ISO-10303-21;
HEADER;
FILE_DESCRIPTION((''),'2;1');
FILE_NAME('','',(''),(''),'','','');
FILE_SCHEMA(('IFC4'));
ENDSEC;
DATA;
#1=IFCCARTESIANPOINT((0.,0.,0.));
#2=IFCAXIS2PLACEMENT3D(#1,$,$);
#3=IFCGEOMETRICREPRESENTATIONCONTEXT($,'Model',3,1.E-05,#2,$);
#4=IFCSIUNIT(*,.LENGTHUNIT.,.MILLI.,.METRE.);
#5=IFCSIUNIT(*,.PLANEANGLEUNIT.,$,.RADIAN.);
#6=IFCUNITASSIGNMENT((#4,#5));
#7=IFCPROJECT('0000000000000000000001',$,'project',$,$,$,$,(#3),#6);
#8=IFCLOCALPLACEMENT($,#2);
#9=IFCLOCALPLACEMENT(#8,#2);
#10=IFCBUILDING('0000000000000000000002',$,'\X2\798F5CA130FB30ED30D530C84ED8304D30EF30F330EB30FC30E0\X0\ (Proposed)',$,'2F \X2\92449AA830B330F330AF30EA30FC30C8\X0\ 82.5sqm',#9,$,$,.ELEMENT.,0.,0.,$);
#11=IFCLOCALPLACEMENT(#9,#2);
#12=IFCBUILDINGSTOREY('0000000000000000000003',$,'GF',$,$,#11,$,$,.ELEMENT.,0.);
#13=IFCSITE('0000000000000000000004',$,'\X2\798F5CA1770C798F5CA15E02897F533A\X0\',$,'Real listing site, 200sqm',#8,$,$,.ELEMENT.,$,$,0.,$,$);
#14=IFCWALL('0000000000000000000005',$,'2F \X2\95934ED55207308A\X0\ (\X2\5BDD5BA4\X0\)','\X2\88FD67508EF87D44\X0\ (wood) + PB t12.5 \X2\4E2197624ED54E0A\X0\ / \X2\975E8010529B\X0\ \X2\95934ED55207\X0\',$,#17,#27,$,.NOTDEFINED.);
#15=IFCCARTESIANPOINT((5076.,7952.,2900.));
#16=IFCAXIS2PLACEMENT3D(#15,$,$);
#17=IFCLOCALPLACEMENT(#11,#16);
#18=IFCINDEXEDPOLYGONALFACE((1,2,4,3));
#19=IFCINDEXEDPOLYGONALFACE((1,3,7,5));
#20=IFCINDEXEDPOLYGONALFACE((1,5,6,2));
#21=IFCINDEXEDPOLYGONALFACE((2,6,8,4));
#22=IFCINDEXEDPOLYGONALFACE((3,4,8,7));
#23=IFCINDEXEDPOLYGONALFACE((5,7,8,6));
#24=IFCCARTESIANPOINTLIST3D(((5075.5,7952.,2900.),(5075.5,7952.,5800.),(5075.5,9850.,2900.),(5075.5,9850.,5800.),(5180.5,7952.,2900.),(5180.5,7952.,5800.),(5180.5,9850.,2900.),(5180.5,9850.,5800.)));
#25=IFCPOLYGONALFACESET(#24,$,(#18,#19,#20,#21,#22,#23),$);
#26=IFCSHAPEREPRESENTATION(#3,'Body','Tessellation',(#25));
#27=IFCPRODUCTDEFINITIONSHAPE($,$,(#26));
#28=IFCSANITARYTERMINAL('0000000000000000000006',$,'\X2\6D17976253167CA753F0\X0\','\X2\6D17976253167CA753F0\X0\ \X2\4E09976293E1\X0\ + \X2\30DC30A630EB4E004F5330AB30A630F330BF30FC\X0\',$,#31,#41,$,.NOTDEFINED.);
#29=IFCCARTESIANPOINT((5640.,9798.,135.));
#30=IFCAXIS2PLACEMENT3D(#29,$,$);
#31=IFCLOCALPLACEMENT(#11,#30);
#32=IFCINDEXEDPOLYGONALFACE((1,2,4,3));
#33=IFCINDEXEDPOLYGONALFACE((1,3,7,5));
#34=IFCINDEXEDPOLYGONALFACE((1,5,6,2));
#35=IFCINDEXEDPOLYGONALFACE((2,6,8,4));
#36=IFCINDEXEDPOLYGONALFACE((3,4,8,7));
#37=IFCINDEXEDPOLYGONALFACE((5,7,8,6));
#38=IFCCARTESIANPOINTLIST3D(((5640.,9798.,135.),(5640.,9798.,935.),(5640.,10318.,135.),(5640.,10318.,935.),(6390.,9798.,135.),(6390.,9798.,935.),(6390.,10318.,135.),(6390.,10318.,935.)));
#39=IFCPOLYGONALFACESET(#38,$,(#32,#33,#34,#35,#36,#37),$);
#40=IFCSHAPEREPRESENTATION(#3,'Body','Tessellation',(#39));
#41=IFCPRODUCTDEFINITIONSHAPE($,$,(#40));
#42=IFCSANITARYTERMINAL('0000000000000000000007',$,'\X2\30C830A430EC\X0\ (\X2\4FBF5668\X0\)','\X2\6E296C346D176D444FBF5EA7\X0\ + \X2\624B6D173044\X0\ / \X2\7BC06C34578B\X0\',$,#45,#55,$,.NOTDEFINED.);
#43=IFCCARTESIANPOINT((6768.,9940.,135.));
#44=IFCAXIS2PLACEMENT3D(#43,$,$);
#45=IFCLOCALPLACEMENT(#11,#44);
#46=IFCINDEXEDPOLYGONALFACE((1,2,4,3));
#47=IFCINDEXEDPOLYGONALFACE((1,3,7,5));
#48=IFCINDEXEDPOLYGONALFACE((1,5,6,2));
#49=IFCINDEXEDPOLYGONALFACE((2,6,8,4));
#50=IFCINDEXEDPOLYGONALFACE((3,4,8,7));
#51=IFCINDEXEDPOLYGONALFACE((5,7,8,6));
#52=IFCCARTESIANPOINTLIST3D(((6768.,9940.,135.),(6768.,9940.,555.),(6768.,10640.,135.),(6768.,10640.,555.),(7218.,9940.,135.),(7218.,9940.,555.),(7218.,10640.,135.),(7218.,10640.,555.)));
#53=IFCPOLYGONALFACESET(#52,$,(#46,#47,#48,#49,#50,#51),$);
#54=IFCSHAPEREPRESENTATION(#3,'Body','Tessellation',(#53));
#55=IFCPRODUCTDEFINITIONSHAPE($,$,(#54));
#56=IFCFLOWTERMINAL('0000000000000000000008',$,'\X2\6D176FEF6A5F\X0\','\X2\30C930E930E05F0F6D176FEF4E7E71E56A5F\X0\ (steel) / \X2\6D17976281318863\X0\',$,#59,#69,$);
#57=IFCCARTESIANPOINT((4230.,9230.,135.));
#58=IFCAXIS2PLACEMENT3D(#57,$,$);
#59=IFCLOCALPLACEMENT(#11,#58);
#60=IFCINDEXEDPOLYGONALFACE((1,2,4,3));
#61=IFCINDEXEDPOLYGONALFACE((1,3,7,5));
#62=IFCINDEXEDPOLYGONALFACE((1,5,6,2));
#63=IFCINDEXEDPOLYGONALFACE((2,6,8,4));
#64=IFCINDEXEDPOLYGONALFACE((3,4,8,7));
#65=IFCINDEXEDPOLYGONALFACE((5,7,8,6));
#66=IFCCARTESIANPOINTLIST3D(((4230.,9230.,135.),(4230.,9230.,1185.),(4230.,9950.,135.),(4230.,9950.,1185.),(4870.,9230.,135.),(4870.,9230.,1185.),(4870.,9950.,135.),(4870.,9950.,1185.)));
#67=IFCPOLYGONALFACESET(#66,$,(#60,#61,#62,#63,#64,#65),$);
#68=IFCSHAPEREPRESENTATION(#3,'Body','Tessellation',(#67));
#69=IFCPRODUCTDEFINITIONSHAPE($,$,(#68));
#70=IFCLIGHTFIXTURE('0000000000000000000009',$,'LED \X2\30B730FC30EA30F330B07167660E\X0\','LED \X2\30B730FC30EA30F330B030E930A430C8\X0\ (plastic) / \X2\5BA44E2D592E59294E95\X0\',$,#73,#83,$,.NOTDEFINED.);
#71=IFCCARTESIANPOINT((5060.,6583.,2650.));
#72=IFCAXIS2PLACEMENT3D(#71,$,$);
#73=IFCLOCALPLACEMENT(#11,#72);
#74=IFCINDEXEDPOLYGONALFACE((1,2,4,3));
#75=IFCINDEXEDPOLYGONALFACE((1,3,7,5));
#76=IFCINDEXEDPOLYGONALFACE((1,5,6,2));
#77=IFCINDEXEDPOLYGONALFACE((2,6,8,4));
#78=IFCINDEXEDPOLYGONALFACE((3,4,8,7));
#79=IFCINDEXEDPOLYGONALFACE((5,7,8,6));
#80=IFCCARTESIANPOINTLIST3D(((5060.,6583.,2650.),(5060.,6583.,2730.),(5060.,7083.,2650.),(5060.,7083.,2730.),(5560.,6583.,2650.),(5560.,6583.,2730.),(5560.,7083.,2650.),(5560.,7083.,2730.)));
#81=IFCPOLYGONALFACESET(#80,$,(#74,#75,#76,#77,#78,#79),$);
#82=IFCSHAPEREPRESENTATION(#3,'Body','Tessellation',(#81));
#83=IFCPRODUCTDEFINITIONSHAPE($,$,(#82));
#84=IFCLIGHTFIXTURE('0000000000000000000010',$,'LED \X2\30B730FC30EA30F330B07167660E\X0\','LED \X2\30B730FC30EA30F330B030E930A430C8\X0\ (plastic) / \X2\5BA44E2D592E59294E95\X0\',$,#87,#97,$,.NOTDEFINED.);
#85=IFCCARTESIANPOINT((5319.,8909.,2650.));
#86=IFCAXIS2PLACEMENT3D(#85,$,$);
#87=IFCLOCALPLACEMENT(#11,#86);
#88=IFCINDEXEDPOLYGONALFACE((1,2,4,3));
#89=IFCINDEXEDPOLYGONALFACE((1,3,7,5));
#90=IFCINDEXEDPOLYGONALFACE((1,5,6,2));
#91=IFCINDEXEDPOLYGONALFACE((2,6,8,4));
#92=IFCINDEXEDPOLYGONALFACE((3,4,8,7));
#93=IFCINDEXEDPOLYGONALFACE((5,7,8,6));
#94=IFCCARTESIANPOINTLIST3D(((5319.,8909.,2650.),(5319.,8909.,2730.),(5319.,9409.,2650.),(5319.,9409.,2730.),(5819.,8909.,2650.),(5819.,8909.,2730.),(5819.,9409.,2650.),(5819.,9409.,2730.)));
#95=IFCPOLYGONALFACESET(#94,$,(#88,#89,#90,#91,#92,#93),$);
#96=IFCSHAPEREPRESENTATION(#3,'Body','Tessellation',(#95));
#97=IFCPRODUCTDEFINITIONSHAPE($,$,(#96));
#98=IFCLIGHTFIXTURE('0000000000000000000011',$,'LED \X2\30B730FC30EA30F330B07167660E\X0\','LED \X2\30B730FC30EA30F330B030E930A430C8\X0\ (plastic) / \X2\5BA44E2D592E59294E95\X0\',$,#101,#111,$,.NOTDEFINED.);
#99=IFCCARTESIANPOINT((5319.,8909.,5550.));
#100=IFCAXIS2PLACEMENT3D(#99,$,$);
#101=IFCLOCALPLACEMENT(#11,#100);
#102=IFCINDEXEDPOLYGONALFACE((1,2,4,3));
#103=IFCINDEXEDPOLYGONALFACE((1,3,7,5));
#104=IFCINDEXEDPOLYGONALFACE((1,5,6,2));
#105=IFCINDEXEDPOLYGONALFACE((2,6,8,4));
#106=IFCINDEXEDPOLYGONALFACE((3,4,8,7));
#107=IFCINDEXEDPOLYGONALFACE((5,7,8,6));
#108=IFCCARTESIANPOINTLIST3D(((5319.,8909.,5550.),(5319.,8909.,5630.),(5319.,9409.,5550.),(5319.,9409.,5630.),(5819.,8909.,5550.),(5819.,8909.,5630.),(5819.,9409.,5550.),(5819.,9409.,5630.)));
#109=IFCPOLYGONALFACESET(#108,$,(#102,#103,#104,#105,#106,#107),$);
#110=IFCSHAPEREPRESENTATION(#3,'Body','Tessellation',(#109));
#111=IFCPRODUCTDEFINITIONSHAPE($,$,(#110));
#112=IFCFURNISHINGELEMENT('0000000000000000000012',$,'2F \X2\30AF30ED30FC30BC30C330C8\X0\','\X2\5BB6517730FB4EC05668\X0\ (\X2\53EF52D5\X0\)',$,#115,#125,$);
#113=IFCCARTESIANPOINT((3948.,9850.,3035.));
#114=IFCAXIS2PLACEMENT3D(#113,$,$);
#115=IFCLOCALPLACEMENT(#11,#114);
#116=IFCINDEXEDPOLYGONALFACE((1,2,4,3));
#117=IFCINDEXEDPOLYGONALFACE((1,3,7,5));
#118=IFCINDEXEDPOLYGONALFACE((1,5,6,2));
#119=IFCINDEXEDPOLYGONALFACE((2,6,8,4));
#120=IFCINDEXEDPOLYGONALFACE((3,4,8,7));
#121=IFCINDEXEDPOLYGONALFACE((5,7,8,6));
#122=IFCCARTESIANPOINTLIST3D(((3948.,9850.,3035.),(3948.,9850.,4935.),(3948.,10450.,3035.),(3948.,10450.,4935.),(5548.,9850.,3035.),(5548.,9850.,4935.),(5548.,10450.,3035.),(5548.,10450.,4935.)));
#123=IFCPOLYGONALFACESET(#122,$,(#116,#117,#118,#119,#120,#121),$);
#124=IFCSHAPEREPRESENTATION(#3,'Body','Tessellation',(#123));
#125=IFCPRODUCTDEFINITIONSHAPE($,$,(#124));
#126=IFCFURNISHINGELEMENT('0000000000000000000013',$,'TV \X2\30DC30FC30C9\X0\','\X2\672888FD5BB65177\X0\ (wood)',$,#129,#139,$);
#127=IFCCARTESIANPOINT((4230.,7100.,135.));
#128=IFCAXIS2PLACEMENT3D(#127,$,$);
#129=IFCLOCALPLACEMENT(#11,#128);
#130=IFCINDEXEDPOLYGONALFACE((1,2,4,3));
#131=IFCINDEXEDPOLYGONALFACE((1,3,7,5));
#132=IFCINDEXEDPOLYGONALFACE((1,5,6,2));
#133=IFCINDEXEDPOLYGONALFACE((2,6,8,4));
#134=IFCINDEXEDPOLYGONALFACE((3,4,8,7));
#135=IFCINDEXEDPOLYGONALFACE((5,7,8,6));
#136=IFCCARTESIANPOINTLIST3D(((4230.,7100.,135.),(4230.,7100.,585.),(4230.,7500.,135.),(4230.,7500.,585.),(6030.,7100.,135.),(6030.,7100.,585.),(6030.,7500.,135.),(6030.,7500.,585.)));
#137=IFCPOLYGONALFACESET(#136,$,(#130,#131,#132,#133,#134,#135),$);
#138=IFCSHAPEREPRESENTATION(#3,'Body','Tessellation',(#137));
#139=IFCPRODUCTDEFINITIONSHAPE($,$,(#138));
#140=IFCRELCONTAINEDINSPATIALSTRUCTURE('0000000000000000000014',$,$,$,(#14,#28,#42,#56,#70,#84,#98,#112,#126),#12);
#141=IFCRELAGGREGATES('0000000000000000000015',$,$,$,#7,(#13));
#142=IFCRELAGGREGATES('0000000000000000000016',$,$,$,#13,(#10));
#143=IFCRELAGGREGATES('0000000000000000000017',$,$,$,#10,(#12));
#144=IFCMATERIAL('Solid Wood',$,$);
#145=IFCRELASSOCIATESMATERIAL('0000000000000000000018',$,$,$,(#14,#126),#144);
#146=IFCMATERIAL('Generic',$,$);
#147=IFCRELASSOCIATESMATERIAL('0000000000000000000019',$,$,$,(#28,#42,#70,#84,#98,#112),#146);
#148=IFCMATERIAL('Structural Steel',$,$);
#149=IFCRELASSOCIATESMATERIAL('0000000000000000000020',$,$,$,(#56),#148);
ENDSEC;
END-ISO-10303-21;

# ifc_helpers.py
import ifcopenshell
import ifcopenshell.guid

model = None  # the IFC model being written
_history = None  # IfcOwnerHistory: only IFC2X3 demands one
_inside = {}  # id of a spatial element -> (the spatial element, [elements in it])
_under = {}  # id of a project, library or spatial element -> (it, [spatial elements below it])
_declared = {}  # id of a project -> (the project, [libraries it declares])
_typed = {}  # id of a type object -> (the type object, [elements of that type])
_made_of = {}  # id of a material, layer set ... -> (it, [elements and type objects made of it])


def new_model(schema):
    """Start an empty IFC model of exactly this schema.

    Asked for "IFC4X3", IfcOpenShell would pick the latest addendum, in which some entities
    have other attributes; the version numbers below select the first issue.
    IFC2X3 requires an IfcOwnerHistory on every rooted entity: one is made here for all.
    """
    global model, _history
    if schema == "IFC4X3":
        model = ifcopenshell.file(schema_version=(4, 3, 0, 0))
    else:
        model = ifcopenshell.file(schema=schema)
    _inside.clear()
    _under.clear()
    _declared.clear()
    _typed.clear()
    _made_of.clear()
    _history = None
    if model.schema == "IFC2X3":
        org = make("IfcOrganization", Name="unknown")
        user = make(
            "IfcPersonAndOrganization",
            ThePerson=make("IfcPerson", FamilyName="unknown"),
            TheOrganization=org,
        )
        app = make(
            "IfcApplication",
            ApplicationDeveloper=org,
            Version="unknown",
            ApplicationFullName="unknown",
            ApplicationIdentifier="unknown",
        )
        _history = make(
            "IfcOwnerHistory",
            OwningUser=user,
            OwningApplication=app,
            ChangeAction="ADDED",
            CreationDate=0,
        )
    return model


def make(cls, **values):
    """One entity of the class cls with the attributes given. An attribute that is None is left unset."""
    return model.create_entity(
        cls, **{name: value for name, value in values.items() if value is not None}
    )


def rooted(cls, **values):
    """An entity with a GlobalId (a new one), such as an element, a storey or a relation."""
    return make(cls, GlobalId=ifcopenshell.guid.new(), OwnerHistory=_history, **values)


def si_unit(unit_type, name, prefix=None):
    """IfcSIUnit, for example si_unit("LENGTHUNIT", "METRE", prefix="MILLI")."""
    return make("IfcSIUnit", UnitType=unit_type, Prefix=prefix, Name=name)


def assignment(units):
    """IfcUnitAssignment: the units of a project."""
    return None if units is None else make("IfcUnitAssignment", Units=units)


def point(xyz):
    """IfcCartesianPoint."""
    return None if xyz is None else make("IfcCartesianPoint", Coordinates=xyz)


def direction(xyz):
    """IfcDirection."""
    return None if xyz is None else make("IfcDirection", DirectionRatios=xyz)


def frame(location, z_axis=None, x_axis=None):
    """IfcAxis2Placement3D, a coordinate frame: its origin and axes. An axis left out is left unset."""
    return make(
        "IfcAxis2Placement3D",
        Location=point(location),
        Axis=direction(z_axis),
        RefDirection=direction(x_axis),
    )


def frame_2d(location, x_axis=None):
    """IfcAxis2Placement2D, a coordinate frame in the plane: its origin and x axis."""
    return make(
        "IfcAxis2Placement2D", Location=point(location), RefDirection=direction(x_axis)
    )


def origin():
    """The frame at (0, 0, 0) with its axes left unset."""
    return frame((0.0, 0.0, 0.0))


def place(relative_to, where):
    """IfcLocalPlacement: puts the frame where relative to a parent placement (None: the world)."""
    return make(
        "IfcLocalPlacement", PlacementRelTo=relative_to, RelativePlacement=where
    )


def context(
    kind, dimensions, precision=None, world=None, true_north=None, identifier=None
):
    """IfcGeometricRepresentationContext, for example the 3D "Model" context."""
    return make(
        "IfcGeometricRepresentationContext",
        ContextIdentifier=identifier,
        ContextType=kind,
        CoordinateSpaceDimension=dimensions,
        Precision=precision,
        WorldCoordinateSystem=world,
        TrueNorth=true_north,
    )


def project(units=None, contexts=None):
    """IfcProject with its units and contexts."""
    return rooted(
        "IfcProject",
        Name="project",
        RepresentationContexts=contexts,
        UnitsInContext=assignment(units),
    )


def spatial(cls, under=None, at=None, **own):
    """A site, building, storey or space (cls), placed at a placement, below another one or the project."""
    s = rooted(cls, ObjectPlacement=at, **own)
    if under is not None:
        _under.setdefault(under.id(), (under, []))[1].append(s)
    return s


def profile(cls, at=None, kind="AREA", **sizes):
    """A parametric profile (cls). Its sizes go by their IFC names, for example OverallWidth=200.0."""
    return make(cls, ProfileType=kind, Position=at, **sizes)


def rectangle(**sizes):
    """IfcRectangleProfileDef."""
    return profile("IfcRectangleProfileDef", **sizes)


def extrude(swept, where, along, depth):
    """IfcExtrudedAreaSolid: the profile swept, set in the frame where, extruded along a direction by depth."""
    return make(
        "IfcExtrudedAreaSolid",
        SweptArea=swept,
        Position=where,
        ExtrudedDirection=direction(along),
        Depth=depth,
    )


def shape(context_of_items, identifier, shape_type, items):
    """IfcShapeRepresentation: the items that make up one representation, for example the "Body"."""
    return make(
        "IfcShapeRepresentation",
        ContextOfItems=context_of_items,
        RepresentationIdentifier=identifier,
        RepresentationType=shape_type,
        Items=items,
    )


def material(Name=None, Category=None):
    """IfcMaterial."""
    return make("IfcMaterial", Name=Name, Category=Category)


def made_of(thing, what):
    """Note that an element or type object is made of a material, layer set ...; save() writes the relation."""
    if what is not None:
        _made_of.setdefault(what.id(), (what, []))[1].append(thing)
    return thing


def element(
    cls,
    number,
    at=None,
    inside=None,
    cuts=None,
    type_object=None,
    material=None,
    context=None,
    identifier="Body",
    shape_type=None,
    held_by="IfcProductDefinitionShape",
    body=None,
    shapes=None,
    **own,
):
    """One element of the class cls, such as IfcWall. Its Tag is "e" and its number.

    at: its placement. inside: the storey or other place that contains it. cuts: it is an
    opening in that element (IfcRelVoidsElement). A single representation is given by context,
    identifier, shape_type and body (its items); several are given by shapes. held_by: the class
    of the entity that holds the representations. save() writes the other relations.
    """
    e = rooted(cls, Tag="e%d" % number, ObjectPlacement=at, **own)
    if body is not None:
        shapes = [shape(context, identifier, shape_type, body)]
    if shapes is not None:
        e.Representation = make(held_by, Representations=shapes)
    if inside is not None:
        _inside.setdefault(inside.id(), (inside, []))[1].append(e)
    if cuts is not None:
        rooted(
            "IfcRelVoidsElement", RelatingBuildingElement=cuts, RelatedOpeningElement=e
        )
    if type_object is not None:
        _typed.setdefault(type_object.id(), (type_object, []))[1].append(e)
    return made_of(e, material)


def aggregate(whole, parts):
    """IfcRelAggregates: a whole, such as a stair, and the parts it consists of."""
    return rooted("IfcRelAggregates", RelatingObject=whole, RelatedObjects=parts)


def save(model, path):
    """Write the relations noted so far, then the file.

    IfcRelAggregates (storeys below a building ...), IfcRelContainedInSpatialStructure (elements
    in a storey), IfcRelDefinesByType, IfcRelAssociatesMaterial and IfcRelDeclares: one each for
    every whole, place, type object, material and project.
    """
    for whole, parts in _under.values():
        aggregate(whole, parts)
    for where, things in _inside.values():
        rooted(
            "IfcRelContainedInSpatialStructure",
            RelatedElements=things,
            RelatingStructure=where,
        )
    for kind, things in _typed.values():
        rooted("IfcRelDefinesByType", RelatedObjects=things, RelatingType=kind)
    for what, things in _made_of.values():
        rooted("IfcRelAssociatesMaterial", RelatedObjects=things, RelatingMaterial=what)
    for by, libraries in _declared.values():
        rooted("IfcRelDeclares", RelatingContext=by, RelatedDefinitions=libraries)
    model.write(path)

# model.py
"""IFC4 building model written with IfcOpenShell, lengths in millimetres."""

from ifc_helpers import new_model, si_unit, frame, frame_2d, origin, place, context, project, spatial, rectangle, extrude, material, element, save


model = new_model("IFC4")

# Units and contexts
model_context = context("Model", 3, precision=1e-05, world=origin())
ifc_project = project(units=[si_unit("LENGTHUNIT", "METRE", prefix="MILLI"), si_unit("PLANEANGLEUNIT", "RADIAN")], contexts=[model_context])

# Site, building, storey
site_placement = place(None, origin())
site = spatial("IfcSite", under=ifc_project, at=site_placement, Name="福岡県福岡市西区", ObjectType="Real listing site, 200sqm", CompositionType="ELEMENT", RefElevation=0.0)
building_placement = place(site_placement, origin())
building = spatial("IfcBuilding", under=site, at=building_placement, Name="福岡・ロフト付きワンルーム (Proposed)", ObjectType="2F 鉄骨コンクリート 82.5sqm", CompositionType="ELEMENT", ElevationOfRefHeight=0.0, ElevationOfTerrain=0.0)
storey_placement = place(building_placement, origin())
storey = spatial("IfcBuildingStorey", under=building, at=storey_placement, Name="GF", CompositionType="ELEMENT", Elevation=0.0)

# Shared definitions
ifc_material_1 = material(Name="Solid Wood")

# Wall
wall_1_placement = place(storey_placement, frame((5076.0, 7952.0, 2900.0)))
element("IfcWall", 1, at=wall_1_placement, inside=storey, material=ifc_material_1, Name="2F 間仕切り (寝室)", Description="製材軸組 (wood) + PB t12.5 両面仕上 / 非耐力 間仕切", PredefinedType="NOTDEFINED", context=model_context, shape_type="SweptSolid", body=[
    extrude(rectangle(XDim=105.0, YDim=1898.0, at=frame_2d((52.0, 949.0))), frame((5076.0, 7952.0, 2900.0)), (0.0, 0.0, 1.0), 2900.0),
])

# Sanitary terminals
ifc_material_2 = material(Name="Generic")
sanitary_terminal_1_placement = place(storey_placement, frame((5640.0, 9798.0, 135.0)))
element("IfcSanitaryTerminal", 2, at=sanitary_terminal_1_placement, inside=storey, material=ifc_material_2, Name="洗面化粧台", Description="洗面化粧台 三面鏡 + ボウル一体カウンター", PredefinedType="NOTDEFINED", context=model_context, shape_type="SweptSolid", body=[
    extrude(rectangle(XDim=750.0, YDim=520.0, at=frame_2d((375.0, 260.0))), frame((5640.0, 9798.0, 135.0)), (0.0, 0.0, 1.0), 800.0),
])
sanitary_terminal_2_placement = place(storey_placement, frame((6768.0, 9940.0, 135.0)))
element("IfcSanitaryTerminal", 3, at=sanitary_terminal_2_placement, inside=storey, material=ifc_material_2, Name="トイレ (便器)", Description="温水洗浄便座 + 手洗い / 節水型", PredefinedType="NOTDEFINED", context=model_context, shape_type="SweptSolid", body=[
    extrude(rectangle(XDim=450.0, YDim=700.0, at=frame_2d((225.0, 350.0))), frame((6768.0, 9940.0, 135.0)), (0.0, 0.0, 1.0), 420.0),
])

# Flow terminal
ifc_material_3 = material(Name="Structural Steel")
flow_terminal_placement = place(storey_placement, frame((4230.0, 9230.0, 135.0)))
element("IfcFlowTerminal", 4, at=flow_terminal_placement, inside=storey, material=ifc_material_3, Name="洗濯機", Description="ドラム式洗濯乾燥機 (steel) / 洗面脱衣", context=model_context, shape_type="SweptSolid", body=[
    extrude(rectangle(XDim=640.0, YDim=720.0, at=frame_2d((320.0, 360.0))), frame((4230.0, 9230.0, 135.0)), (0.0, 0.0, 1.0), 1050.0),
])

# Light fixtures
light_fixture_1_placement = place(storey_placement, frame((5060.0, 6583.0, 2650.0)))
element("IfcLightFixture", 5, at=light_fixture_1_placement, inside=storey, material=ifc_material_2, Name="LED シーリング照明", Description="LED シーリングライト (plastic) / 室中央天井", PredefinedType="NOTDEFINED", context=model_context, shape_type="SweptSolid", body=[
    extrude(rectangle(XDim=500.0, YDim=500.0, at=frame_2d((250.0, 250.0))), frame((5060.0, 6583.0, 2650.0)), (0.0, 0.0, 1.0), 80.0),
])
light_fixture_2_placement = place(storey_placement, frame((5319.0, 8909.0, 2650.0)))
element("IfcLightFixture", 6, at=light_fixture_2_placement, inside=storey, material=ifc_material_2, Name="LED シーリング照明", Description="LED シーリングライト (plastic) / 室中央天井", PredefinedType="NOTDEFINED", context=model_context, shape_type="SweptSolid", body=[
    extrude(rectangle(XDim=500.0, YDim=500.0, at=frame_2d((250.0, 250.0))), frame((5319.0, 8909.0, 2650.0)), (0.0, 0.0, 1.0), 80.0),
])
light_fixture_3_placement = place(storey_placement, frame((5319.0, 8909.0, 5550.0)))
element("IfcLightFixture", 7, at=light_fixture_3_placement, inside=storey, material=ifc_material_2, Name="LED シーリング照明", Description="LED シーリングライト (plastic) / 室中央天井", PredefinedType="NOTDEFINED", context=model_context, shape_type="SweptSolid", body=[
    extrude(rectangle(XDim=500.0, YDim=500.0, at=frame_2d((250.0, 250.0))), frame((5319.0, 8909.0, 5550.0)), (0.0, 0.0, 1.0), 80.0),
])

# Furnishing elements
furnishing_1_placement = place(storey_placement, frame((3948.0, 9850.0, 3035.0)))
element("IfcFurnishingElement", 8, at=furnishing_1_placement, inside=storey, material=ifc_material_2, Name="2F クローゼット", Description="家具・什器 (可動)", context=model_context, shape_type="SweptSolid", body=[
    extrude(rectangle(XDim=1600.0, YDim=600.0, at=frame_2d((800.0, 300.0))), frame((3948.0, 9850.0, 3035.0)), (0.0, 0.0, 1.0), 1900.0),
])
furnishing_2_placement = place(storey_placement, frame((4230.0, 7100.0, 135.0)))
element("IfcFurnishingElement", 9, at=furnishing_2_placement, inside=storey, material=ifc_material_1, Name="TV ボード", Description="木製家具 (wood)", context=model_context, shape_type="SweptSolid", body=[
    extrude(rectangle(XDim=1800.0, YDim=400.0, at=frame_2d((900.0, 200.0))), frame((4230.0, 7100.0, 135.0)), (0.0, 0.0, 1.0), 450.0),
])

save(model, "model.ifc")
